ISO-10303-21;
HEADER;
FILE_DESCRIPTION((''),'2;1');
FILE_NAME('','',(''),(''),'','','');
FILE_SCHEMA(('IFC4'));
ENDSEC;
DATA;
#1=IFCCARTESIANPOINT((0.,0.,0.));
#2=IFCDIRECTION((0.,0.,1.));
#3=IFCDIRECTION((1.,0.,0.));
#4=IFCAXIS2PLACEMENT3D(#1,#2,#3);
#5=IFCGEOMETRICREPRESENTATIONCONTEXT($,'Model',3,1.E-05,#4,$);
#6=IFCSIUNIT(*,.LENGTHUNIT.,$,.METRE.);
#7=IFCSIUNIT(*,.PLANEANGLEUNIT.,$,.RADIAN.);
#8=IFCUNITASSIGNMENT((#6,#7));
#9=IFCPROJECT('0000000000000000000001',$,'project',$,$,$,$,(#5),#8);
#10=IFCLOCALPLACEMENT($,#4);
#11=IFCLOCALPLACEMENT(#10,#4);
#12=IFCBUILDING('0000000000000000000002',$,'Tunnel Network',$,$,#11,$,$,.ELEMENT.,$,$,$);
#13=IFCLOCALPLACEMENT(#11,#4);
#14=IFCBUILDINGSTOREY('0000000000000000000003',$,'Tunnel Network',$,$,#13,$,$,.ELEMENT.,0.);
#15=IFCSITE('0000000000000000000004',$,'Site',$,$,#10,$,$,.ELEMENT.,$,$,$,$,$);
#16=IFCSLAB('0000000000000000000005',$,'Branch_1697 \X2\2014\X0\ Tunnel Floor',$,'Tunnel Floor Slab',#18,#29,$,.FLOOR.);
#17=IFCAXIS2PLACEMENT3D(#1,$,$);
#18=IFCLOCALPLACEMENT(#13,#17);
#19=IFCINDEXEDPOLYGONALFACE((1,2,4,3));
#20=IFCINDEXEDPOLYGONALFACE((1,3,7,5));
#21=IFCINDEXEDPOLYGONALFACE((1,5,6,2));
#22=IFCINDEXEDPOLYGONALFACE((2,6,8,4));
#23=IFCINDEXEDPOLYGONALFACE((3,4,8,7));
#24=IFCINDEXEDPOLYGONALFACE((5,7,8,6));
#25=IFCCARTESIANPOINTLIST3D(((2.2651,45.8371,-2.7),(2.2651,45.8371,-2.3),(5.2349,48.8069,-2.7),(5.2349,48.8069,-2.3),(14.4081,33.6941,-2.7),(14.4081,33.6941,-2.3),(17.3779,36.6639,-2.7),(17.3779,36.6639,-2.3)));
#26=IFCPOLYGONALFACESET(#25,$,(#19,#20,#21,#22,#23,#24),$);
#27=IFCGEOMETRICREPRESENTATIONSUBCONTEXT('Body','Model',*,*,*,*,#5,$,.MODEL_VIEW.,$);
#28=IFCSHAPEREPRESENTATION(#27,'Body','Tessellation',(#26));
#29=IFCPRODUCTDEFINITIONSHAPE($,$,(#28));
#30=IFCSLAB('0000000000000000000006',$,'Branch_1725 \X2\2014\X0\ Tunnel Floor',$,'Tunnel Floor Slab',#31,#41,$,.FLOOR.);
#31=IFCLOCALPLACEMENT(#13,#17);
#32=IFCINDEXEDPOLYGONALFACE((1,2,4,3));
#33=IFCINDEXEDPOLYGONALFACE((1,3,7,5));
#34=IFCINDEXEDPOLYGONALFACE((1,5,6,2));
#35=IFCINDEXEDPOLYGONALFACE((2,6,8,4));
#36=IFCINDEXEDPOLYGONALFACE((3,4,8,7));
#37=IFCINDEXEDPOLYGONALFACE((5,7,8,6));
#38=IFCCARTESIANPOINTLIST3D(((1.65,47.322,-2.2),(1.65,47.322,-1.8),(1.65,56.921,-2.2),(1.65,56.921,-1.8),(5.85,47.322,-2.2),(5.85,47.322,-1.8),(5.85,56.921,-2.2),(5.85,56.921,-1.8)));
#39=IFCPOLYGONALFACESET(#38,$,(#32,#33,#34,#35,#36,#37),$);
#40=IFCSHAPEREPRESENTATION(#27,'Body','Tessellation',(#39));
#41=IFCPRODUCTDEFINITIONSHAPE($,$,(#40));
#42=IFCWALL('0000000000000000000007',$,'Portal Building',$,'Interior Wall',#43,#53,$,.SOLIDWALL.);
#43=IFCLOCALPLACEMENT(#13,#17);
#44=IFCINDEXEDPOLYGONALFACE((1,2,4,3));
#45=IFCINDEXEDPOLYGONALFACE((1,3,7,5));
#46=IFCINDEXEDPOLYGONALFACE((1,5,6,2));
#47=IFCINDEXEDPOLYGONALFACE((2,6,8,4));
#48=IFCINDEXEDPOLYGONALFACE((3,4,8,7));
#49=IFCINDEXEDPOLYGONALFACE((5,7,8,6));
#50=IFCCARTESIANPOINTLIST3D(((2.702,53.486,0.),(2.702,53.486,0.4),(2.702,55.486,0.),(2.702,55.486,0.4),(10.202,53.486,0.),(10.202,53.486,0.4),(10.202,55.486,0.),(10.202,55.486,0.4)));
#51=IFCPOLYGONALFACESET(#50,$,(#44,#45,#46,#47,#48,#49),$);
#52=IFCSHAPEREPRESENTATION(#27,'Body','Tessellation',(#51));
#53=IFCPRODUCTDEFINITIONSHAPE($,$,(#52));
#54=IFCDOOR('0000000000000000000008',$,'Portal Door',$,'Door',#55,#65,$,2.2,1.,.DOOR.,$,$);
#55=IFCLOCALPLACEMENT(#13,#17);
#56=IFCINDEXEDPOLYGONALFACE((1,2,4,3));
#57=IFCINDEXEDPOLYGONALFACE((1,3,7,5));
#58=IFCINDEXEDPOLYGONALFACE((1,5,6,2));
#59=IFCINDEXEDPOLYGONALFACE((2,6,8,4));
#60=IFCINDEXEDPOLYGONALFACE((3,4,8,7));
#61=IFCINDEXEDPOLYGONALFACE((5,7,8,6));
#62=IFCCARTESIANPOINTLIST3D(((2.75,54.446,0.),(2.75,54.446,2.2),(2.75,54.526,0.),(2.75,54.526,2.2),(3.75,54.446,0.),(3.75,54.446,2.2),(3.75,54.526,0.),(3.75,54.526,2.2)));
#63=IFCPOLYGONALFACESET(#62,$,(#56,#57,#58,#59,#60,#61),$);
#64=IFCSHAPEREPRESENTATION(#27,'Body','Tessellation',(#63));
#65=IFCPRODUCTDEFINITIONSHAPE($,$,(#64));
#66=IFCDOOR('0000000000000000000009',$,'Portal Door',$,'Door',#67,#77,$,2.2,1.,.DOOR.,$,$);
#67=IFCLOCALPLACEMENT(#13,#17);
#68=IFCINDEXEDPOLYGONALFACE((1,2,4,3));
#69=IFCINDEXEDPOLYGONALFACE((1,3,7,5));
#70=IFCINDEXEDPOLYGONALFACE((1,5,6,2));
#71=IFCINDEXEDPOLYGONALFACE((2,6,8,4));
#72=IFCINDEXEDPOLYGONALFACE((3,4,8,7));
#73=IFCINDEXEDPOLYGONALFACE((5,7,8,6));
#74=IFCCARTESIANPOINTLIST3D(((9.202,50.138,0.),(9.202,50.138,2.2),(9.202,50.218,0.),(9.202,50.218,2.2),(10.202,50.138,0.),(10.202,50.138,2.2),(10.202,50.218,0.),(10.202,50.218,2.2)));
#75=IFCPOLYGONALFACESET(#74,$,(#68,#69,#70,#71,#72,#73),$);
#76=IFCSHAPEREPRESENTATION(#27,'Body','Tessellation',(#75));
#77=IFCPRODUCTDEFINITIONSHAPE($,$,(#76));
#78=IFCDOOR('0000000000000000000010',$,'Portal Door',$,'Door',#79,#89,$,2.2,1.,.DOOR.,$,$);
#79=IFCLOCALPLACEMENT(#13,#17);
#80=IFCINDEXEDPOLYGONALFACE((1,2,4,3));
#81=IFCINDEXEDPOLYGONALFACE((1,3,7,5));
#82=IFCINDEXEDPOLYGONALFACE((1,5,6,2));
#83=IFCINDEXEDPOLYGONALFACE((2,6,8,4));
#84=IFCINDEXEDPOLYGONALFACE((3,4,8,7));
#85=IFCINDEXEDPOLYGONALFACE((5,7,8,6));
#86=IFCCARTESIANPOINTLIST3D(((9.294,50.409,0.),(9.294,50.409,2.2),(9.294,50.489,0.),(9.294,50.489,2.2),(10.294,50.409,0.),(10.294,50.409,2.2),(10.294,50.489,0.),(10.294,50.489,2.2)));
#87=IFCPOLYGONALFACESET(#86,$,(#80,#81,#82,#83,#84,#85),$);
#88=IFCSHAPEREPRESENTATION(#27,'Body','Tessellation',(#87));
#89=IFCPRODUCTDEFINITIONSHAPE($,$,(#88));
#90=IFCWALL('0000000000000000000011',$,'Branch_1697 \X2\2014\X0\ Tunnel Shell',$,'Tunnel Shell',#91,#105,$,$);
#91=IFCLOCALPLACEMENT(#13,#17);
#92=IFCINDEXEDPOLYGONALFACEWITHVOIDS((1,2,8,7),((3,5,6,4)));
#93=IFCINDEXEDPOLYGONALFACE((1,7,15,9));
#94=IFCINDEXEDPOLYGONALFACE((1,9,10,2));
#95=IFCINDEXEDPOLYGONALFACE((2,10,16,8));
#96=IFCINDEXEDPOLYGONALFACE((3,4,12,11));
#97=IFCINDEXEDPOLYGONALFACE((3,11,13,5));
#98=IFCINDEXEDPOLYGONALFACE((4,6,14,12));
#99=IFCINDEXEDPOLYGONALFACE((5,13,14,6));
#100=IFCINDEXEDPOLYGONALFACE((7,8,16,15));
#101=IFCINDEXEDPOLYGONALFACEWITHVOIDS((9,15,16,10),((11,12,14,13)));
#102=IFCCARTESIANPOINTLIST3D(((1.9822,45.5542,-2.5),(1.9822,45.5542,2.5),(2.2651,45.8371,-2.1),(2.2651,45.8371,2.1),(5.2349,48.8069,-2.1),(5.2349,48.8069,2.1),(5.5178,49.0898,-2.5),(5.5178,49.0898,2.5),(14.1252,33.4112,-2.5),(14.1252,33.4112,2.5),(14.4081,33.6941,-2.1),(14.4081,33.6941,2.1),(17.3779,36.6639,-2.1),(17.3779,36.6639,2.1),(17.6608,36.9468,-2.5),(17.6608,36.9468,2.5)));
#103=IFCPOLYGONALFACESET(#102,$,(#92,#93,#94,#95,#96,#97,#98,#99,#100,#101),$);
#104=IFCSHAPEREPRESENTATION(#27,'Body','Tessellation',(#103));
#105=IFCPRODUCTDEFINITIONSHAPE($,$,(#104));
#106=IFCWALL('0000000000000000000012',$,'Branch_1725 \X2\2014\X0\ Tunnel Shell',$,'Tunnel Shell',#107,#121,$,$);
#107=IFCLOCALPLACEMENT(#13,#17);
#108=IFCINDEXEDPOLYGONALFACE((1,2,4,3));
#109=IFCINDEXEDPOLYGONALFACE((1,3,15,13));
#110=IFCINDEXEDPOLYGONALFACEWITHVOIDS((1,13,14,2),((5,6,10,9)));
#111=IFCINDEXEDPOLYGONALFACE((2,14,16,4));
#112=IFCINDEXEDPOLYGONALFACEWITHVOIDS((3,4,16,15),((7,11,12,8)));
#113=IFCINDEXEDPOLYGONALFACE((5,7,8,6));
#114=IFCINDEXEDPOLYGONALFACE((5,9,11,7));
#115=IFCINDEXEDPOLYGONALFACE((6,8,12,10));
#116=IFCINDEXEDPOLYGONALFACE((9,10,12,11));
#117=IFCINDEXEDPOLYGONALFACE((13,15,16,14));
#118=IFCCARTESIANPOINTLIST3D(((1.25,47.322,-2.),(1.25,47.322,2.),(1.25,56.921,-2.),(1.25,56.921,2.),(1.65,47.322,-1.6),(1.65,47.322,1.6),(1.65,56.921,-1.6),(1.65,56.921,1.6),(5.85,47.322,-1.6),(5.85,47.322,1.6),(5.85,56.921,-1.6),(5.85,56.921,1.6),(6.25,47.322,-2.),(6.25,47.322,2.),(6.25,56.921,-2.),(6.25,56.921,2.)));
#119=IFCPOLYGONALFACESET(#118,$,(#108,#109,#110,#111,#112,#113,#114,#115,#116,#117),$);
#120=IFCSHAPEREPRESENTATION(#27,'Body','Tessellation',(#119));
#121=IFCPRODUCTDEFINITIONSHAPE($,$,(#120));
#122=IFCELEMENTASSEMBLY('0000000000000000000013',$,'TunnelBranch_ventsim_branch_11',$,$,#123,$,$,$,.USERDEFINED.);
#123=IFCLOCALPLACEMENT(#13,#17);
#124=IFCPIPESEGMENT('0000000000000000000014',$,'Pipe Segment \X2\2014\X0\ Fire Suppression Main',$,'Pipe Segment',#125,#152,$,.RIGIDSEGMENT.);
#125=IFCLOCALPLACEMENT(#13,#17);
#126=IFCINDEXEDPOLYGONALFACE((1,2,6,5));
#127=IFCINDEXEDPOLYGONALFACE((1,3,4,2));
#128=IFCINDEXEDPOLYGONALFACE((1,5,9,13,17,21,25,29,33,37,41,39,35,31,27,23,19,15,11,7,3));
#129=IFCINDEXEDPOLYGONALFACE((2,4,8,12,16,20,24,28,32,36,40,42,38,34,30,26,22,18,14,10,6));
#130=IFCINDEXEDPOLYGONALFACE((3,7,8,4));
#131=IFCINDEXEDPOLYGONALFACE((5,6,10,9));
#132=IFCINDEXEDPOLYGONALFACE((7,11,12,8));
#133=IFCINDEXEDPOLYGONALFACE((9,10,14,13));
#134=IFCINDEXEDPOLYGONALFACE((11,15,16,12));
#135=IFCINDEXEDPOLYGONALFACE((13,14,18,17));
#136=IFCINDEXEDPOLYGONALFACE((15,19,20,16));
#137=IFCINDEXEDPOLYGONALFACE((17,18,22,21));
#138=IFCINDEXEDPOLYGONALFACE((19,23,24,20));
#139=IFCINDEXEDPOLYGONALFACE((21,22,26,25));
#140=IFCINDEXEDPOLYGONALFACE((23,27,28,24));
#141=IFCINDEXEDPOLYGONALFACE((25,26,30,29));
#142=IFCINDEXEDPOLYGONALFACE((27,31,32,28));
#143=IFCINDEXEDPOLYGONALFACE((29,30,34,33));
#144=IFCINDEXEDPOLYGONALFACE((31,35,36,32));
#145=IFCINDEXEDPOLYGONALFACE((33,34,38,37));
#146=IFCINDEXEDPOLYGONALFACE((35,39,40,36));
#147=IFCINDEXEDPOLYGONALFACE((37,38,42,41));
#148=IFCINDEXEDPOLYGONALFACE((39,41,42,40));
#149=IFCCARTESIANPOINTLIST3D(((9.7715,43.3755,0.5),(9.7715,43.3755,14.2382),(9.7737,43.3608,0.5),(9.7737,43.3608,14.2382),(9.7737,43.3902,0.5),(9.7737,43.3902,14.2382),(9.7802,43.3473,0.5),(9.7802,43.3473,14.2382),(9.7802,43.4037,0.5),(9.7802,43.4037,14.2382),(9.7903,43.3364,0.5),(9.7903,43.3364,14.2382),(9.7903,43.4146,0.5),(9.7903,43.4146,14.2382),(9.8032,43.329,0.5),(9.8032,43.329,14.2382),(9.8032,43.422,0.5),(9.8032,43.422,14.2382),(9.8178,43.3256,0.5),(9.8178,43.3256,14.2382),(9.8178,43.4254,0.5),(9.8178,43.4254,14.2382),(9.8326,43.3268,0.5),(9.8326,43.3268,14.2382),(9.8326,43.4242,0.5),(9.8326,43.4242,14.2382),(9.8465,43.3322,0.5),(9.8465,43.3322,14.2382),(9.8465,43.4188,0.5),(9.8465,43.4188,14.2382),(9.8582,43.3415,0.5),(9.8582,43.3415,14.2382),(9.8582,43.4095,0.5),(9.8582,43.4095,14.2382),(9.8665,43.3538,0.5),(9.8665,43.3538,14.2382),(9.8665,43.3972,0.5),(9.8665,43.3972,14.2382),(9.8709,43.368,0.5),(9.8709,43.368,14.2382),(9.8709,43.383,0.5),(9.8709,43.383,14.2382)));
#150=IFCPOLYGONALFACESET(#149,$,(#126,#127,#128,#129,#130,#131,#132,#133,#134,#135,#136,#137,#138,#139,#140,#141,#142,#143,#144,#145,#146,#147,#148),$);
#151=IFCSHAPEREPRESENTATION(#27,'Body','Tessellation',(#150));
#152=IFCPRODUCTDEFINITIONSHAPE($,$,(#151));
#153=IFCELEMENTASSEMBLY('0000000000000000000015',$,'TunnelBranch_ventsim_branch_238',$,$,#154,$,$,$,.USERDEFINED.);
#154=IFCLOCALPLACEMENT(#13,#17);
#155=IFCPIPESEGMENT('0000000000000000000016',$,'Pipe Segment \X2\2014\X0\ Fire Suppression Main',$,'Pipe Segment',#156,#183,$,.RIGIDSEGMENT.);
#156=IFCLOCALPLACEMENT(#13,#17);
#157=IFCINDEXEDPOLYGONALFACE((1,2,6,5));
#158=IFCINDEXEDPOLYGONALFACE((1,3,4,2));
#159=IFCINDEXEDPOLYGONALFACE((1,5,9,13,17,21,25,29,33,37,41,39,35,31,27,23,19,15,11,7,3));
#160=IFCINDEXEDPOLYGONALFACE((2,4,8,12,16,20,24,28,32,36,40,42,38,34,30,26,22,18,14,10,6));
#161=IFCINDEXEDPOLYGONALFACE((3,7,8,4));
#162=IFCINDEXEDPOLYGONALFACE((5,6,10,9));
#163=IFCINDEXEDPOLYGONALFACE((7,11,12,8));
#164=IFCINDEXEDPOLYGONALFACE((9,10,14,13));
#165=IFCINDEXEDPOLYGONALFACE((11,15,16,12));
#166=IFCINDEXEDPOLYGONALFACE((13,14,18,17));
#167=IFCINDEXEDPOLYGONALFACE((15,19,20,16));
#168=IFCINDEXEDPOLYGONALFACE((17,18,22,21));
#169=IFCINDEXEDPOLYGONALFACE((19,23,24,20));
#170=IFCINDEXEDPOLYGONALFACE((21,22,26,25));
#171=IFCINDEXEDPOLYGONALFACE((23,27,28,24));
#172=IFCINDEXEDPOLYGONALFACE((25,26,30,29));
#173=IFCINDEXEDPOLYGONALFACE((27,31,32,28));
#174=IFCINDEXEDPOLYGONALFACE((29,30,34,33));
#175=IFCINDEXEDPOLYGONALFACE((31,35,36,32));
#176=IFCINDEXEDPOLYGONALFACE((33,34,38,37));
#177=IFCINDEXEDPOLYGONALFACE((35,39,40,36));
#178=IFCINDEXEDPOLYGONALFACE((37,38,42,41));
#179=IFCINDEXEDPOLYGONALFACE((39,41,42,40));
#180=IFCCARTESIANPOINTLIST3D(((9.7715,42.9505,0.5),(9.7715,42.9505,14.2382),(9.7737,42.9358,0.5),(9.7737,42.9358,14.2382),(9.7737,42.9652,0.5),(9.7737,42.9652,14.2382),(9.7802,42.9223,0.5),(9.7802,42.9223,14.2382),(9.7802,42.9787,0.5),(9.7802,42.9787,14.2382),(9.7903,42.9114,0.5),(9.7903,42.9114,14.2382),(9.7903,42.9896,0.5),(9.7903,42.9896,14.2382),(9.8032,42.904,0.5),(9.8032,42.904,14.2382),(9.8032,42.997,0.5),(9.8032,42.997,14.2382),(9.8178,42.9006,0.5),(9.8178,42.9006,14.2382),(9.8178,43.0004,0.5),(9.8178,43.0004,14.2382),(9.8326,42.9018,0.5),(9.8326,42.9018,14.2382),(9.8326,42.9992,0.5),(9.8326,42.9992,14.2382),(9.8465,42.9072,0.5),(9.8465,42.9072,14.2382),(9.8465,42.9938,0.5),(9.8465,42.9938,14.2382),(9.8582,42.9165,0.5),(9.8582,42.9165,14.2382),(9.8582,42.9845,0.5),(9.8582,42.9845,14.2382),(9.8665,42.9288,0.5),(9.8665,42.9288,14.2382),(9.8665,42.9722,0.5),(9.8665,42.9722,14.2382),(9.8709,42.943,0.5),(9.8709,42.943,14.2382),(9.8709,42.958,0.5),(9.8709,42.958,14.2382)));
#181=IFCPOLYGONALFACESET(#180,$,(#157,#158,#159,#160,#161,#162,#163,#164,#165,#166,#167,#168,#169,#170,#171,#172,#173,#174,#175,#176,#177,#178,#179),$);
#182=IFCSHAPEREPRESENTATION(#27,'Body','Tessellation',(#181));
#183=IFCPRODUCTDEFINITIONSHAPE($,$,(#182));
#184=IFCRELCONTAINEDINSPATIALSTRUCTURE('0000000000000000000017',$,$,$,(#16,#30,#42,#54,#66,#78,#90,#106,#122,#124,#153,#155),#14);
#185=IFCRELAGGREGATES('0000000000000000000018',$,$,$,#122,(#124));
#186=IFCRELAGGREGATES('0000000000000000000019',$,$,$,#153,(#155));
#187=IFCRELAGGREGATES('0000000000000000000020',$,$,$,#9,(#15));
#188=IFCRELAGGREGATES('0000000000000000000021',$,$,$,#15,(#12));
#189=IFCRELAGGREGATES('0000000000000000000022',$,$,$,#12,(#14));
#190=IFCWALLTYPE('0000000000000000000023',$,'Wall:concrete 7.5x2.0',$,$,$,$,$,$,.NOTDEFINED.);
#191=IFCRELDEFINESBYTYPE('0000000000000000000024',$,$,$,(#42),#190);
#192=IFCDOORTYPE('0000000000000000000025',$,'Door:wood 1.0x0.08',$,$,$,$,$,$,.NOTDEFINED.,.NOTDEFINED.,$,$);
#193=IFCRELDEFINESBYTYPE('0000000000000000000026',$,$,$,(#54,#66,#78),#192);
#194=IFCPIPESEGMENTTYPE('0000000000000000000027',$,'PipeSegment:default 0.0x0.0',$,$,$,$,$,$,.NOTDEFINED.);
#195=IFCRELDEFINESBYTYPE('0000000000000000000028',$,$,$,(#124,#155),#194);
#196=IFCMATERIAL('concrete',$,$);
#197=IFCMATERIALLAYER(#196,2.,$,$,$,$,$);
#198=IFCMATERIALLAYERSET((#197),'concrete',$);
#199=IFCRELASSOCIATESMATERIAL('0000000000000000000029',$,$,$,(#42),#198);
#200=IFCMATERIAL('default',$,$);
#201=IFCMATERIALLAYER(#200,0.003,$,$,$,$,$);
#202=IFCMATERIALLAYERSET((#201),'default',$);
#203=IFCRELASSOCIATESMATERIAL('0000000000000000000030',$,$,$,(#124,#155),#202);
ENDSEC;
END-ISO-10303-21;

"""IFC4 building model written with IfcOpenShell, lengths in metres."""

from ifc_helpers import new_model, si_unit, frame, origin_with_axes, origin_2d_with_axis, place, context, subcontext, project, spatial, rectangle, hollow_rectangle, circle, extrude, material, layer, layer_set, layer_usage, type_object, element, aggregate, save


model = new_model("IFC4")

# Units and contexts
model_context = context("Model", 3, precision=1e-05, world=origin_with_axes())
body_context = subcontext(model_context, "Body", "Model", "MODEL_VIEW")
ifc_project = project(units=[si_unit("LENGTHUNIT", "METRE"), si_unit("PLANEANGLEUNIT", "RADIAN")], contexts=[model_context])

# Site, building, storey
site_placement = place(None, origin_with_axes())
site = spatial("IfcSite", under=ifc_project, at=site_placement, Name="Site", CompositionType="ELEMENT")
building_placement = place(site_placement, origin_with_axes())
building = spatial("IfcBuilding", under=site, at=building_placement, Name="Tunnel Network", CompositionType="ELEMENT")
storey_placement = place(building_placement, origin_with_axes())
storey = spatial("IfcBuildingStorey", under=building, at=storey_placement, Name="Tunnel Network", CompositionType="ELEMENT", Elevation=0.0)

# Slabs
placement_1 = place(storey_placement, frame((3.75, 47.322, 0.0), z_axis=(0.0, 0.0, 1.0), x_axis=(0.707107, -0.707107, 0.0)))
element("IfcSlab", 1, at=placement_1, inside=storey, Name="Branch_1697 — Tunnel Floor", ObjectType="Tunnel Floor Slab", PredefinedType="FLOOR", context=body_context, shape_type="SweptSolid", body=[
    extrude(rectangle(XDim=0.4, YDim=4.2, at=origin_2d_with_axis()), frame((0.0, 0.0, -2.5), z_axis=(1.0, 0.0, 0.0), x_axis=(0.0, 0.0, 1.0)), (0.0, 0.0, 1.0), 17.1728),
])
placement_2 = place(storey_placement, frame((3.75, 47.322, 0.0), z_axis=(0.0, 0.0, 1.0), x_axis=(0.0, 1.0, 0.0)))
element("IfcSlab", 2, at=placement_2, inside=storey, Name="Branch_1725 — Tunnel Floor", ObjectType="Tunnel Floor Slab", PredefinedType="FLOOR", context=body_context, shape_type="SweptSolid", body=[
    extrude(rectangle(XDim=0.4, YDim=4.2, at=origin_2d_with_axis()), frame((0.0, 0.0, -2.0), z_axis=(1.0, 0.0, 0.0), x_axis=(0.0, 0.0, 1.0)), (0.0, 0.0, 1.0), 9.599),
])

# Wall
ifc_material_1 = material(Name="concrete")
ifc_layer_1 = layer(ifc_material_1, 2.0)
ifc_layer_set_1 = layer_set([ifc_layer_1], Name="concrete")
ifc_layer_usage_1 = layer_usage(ifc_layer_set_1, "AXIS2", "POSITIVE", 0.0)
wall_type = type_object("IfcWallType", Name="Wall:concrete 7.5x2.0")
wall_1_placement = place(storey_placement, frame((6.452, 54.486, 0.0), z_axis=(0.0, 0.0, 1.0), x_axis=(1.0, 0.0, 0.0)))
element("IfcWall", 3, at=wall_1_placement, inside=storey, type_object=wall_type, material=ifc_layer_usage_1, Name="Portal Building", ObjectType="Interior Wall", PredefinedType="SOLIDWALL", context=body_context, shape_type="SweptSolid", body=[
    extrude(rectangle(XDim=7.5, YDim=2.0, at=origin_2d_with_axis()), origin_with_axes(), (0.0, 0.0, 1.0), 0.4),
])

# Doors
door_type = type_object("IfcDoorType", Name="Door:wood 1.0x0.08")
for number, where, z_axis, x_axis, name in (
    (4, (3.25, 54.486, 0.0), (0.0, 0.0, 1.0), (1.0, 0.0, 0.0), "Portal Door"),
    (5, (9.702, 50.178, 0.0), (0.0, 0.0, 1.0), (1.0, 0.0, 0.0), "Portal Door"),
    (6, (9.794, 50.449, 0.0), (0.0, 0.0, 1.0), (1.0, 0.0, 0.0), "Portal Door"),
):
    element("IfcDoor", number, at=place(storey_placement, frame(where, z_axis=z_axis, x_axis=x_axis)), inside=storey, type_object=door_type, Name=name, ObjectType="Door", OverallHeight=2.2, OverallWidth=1.0, PredefinedType="DOOR", context=body_context, shape_type="SweptSolid", body=[
        extrude(rectangle(XDim=1.0, YDim=0.08, at=origin_2d_with_axis()), origin_with_axes(), (0.0, 0.0, 1.0), 2.2),
    ])

# Walls
element("IfcWall", 7, at=placement_1, inside=storey, Name="Branch_1697 — Tunnel Shell", ObjectType="Tunnel Shell", context=body_context, shape_type="SweptSolid", body=[
    extrude(hollow_rectangle(XDim=5.0, YDim=5.0, WallThickness=0.4, at=origin_2d_with_axis()), frame((0.0, 0.0, 0.0), z_axis=(1.0, 0.0, 0.0), x_axis=(0.0, 0.0, 1.0)), (0.0, 0.0, 1.0), 17.1728),
])
element("IfcWall", 8, at=placement_2, inside=storey, Name="Branch_1725 — Tunnel Shell", ObjectType="Tunnel Shell", context=body_context, shape_type="SweptSolid", body=[
    extrude(hollow_rectangle(XDim=4.0, YDim=5.0, WallThickness=0.4, at=origin_2d_with_axis()), frame((0.0, 0.0, 0.0), z_axis=(1.0, 0.0, 0.0), x_axis=(0.0, 0.0, 1.0)), (0.0, 0.0, 1.0), 9.599),
])

# Element assemblies, pipe segments
assembly_1_placement = place(storey_placement, frame((9.8215, 43.3755, 1.25), z_axis=(0.0, 1.0, 0.0), x_axis=(-1.0, 0.0, 0.0)))
assembly_1 = element("IfcElementAssembly", 9, at=assembly_1_placement, inside=storey, Name="TunnelBranch_ventsim_branch_11", PredefinedType="USERDEFINED")
ifc_material_2 = material(Name="default")
ifc_layer_2 = layer(ifc_material_2, 0.003)
ifc_layer_set_2 = layer_set([ifc_layer_2], Name="default")
ifc_layer_usage_2 = layer_usage(ifc_layer_set_2, "AXIS2", "POSITIVE", 0.0)
pipe_segment_type = type_object("IfcPipeSegmentType", Name="PipeSegment:default 0.0x0.0")
pipe_segment_1_placement = place(storey_placement, frame((9.8215, 43.3755, 0.5), z_axis=(0.0, 0.0, 1.0), x_axis=(-1.0, 0.0, 0.0)))
pipe_segment_1 = element("IfcPipeSegment", 10, at=pipe_segment_1_placement, inside=storey, type_object=pipe_segment_type, material=ifc_layer_usage_2, Name="Pipe Segment — Fire Suppression Main", ObjectType="Pipe Segment", PredefinedType="RIGIDSEGMENT", context=body_context, shape_type="SweptSolid", body=[
    extrude(circle(Radius=0.05, at=origin_2d_with_axis()), origin_with_axes(), (0.0, 0.0, 1.0), 13.7382),
])
assembly_2_placement = place(storey_placement, frame((9.8215, 42.9505, 1.25), z_axis=(0.0, 1.0, 0.0), x_axis=(-1.0, 0.0, 0.0)))
assembly_2 = element("IfcElementAssembly", 11, at=assembly_2_placement, inside=storey, Name="TunnelBranch_ventsim_branch_238", PredefinedType="USERDEFINED")
ifc_layer_usage_3 = layer_usage(ifc_layer_set_2, "AXIS2", "POSITIVE", 0.0)
pipe_segment_2_placement = place(storey_placement, frame((9.8215, 42.9505, 0.5), z_axis=(0.0, 0.0, 1.0), x_axis=(-1.0, 0.0, 0.0)))
pipe_segment_2 = element("IfcPipeSegment", 12, at=pipe_segment_2_placement, inside=storey, type_object=pipe_segment_type, material=ifc_layer_usage_3, Name="Pipe Segment — Fire Suppression Main", ObjectType="Pipe Segment", PredefinedType="RIGIDSEGMENT", context=body_context, shape_type="SweptSolid", body=[
    extrude(circle(Radius=0.05, at=origin_2d_with_axis()), origin_with_axes(), (0.0, 0.0, 1.0), 13.7382),
])

aggregate(assembly_1, [pipe_segment_1])

aggregate(assembly_2, [pipe_segment_2])

save(model, "model.ifc")
